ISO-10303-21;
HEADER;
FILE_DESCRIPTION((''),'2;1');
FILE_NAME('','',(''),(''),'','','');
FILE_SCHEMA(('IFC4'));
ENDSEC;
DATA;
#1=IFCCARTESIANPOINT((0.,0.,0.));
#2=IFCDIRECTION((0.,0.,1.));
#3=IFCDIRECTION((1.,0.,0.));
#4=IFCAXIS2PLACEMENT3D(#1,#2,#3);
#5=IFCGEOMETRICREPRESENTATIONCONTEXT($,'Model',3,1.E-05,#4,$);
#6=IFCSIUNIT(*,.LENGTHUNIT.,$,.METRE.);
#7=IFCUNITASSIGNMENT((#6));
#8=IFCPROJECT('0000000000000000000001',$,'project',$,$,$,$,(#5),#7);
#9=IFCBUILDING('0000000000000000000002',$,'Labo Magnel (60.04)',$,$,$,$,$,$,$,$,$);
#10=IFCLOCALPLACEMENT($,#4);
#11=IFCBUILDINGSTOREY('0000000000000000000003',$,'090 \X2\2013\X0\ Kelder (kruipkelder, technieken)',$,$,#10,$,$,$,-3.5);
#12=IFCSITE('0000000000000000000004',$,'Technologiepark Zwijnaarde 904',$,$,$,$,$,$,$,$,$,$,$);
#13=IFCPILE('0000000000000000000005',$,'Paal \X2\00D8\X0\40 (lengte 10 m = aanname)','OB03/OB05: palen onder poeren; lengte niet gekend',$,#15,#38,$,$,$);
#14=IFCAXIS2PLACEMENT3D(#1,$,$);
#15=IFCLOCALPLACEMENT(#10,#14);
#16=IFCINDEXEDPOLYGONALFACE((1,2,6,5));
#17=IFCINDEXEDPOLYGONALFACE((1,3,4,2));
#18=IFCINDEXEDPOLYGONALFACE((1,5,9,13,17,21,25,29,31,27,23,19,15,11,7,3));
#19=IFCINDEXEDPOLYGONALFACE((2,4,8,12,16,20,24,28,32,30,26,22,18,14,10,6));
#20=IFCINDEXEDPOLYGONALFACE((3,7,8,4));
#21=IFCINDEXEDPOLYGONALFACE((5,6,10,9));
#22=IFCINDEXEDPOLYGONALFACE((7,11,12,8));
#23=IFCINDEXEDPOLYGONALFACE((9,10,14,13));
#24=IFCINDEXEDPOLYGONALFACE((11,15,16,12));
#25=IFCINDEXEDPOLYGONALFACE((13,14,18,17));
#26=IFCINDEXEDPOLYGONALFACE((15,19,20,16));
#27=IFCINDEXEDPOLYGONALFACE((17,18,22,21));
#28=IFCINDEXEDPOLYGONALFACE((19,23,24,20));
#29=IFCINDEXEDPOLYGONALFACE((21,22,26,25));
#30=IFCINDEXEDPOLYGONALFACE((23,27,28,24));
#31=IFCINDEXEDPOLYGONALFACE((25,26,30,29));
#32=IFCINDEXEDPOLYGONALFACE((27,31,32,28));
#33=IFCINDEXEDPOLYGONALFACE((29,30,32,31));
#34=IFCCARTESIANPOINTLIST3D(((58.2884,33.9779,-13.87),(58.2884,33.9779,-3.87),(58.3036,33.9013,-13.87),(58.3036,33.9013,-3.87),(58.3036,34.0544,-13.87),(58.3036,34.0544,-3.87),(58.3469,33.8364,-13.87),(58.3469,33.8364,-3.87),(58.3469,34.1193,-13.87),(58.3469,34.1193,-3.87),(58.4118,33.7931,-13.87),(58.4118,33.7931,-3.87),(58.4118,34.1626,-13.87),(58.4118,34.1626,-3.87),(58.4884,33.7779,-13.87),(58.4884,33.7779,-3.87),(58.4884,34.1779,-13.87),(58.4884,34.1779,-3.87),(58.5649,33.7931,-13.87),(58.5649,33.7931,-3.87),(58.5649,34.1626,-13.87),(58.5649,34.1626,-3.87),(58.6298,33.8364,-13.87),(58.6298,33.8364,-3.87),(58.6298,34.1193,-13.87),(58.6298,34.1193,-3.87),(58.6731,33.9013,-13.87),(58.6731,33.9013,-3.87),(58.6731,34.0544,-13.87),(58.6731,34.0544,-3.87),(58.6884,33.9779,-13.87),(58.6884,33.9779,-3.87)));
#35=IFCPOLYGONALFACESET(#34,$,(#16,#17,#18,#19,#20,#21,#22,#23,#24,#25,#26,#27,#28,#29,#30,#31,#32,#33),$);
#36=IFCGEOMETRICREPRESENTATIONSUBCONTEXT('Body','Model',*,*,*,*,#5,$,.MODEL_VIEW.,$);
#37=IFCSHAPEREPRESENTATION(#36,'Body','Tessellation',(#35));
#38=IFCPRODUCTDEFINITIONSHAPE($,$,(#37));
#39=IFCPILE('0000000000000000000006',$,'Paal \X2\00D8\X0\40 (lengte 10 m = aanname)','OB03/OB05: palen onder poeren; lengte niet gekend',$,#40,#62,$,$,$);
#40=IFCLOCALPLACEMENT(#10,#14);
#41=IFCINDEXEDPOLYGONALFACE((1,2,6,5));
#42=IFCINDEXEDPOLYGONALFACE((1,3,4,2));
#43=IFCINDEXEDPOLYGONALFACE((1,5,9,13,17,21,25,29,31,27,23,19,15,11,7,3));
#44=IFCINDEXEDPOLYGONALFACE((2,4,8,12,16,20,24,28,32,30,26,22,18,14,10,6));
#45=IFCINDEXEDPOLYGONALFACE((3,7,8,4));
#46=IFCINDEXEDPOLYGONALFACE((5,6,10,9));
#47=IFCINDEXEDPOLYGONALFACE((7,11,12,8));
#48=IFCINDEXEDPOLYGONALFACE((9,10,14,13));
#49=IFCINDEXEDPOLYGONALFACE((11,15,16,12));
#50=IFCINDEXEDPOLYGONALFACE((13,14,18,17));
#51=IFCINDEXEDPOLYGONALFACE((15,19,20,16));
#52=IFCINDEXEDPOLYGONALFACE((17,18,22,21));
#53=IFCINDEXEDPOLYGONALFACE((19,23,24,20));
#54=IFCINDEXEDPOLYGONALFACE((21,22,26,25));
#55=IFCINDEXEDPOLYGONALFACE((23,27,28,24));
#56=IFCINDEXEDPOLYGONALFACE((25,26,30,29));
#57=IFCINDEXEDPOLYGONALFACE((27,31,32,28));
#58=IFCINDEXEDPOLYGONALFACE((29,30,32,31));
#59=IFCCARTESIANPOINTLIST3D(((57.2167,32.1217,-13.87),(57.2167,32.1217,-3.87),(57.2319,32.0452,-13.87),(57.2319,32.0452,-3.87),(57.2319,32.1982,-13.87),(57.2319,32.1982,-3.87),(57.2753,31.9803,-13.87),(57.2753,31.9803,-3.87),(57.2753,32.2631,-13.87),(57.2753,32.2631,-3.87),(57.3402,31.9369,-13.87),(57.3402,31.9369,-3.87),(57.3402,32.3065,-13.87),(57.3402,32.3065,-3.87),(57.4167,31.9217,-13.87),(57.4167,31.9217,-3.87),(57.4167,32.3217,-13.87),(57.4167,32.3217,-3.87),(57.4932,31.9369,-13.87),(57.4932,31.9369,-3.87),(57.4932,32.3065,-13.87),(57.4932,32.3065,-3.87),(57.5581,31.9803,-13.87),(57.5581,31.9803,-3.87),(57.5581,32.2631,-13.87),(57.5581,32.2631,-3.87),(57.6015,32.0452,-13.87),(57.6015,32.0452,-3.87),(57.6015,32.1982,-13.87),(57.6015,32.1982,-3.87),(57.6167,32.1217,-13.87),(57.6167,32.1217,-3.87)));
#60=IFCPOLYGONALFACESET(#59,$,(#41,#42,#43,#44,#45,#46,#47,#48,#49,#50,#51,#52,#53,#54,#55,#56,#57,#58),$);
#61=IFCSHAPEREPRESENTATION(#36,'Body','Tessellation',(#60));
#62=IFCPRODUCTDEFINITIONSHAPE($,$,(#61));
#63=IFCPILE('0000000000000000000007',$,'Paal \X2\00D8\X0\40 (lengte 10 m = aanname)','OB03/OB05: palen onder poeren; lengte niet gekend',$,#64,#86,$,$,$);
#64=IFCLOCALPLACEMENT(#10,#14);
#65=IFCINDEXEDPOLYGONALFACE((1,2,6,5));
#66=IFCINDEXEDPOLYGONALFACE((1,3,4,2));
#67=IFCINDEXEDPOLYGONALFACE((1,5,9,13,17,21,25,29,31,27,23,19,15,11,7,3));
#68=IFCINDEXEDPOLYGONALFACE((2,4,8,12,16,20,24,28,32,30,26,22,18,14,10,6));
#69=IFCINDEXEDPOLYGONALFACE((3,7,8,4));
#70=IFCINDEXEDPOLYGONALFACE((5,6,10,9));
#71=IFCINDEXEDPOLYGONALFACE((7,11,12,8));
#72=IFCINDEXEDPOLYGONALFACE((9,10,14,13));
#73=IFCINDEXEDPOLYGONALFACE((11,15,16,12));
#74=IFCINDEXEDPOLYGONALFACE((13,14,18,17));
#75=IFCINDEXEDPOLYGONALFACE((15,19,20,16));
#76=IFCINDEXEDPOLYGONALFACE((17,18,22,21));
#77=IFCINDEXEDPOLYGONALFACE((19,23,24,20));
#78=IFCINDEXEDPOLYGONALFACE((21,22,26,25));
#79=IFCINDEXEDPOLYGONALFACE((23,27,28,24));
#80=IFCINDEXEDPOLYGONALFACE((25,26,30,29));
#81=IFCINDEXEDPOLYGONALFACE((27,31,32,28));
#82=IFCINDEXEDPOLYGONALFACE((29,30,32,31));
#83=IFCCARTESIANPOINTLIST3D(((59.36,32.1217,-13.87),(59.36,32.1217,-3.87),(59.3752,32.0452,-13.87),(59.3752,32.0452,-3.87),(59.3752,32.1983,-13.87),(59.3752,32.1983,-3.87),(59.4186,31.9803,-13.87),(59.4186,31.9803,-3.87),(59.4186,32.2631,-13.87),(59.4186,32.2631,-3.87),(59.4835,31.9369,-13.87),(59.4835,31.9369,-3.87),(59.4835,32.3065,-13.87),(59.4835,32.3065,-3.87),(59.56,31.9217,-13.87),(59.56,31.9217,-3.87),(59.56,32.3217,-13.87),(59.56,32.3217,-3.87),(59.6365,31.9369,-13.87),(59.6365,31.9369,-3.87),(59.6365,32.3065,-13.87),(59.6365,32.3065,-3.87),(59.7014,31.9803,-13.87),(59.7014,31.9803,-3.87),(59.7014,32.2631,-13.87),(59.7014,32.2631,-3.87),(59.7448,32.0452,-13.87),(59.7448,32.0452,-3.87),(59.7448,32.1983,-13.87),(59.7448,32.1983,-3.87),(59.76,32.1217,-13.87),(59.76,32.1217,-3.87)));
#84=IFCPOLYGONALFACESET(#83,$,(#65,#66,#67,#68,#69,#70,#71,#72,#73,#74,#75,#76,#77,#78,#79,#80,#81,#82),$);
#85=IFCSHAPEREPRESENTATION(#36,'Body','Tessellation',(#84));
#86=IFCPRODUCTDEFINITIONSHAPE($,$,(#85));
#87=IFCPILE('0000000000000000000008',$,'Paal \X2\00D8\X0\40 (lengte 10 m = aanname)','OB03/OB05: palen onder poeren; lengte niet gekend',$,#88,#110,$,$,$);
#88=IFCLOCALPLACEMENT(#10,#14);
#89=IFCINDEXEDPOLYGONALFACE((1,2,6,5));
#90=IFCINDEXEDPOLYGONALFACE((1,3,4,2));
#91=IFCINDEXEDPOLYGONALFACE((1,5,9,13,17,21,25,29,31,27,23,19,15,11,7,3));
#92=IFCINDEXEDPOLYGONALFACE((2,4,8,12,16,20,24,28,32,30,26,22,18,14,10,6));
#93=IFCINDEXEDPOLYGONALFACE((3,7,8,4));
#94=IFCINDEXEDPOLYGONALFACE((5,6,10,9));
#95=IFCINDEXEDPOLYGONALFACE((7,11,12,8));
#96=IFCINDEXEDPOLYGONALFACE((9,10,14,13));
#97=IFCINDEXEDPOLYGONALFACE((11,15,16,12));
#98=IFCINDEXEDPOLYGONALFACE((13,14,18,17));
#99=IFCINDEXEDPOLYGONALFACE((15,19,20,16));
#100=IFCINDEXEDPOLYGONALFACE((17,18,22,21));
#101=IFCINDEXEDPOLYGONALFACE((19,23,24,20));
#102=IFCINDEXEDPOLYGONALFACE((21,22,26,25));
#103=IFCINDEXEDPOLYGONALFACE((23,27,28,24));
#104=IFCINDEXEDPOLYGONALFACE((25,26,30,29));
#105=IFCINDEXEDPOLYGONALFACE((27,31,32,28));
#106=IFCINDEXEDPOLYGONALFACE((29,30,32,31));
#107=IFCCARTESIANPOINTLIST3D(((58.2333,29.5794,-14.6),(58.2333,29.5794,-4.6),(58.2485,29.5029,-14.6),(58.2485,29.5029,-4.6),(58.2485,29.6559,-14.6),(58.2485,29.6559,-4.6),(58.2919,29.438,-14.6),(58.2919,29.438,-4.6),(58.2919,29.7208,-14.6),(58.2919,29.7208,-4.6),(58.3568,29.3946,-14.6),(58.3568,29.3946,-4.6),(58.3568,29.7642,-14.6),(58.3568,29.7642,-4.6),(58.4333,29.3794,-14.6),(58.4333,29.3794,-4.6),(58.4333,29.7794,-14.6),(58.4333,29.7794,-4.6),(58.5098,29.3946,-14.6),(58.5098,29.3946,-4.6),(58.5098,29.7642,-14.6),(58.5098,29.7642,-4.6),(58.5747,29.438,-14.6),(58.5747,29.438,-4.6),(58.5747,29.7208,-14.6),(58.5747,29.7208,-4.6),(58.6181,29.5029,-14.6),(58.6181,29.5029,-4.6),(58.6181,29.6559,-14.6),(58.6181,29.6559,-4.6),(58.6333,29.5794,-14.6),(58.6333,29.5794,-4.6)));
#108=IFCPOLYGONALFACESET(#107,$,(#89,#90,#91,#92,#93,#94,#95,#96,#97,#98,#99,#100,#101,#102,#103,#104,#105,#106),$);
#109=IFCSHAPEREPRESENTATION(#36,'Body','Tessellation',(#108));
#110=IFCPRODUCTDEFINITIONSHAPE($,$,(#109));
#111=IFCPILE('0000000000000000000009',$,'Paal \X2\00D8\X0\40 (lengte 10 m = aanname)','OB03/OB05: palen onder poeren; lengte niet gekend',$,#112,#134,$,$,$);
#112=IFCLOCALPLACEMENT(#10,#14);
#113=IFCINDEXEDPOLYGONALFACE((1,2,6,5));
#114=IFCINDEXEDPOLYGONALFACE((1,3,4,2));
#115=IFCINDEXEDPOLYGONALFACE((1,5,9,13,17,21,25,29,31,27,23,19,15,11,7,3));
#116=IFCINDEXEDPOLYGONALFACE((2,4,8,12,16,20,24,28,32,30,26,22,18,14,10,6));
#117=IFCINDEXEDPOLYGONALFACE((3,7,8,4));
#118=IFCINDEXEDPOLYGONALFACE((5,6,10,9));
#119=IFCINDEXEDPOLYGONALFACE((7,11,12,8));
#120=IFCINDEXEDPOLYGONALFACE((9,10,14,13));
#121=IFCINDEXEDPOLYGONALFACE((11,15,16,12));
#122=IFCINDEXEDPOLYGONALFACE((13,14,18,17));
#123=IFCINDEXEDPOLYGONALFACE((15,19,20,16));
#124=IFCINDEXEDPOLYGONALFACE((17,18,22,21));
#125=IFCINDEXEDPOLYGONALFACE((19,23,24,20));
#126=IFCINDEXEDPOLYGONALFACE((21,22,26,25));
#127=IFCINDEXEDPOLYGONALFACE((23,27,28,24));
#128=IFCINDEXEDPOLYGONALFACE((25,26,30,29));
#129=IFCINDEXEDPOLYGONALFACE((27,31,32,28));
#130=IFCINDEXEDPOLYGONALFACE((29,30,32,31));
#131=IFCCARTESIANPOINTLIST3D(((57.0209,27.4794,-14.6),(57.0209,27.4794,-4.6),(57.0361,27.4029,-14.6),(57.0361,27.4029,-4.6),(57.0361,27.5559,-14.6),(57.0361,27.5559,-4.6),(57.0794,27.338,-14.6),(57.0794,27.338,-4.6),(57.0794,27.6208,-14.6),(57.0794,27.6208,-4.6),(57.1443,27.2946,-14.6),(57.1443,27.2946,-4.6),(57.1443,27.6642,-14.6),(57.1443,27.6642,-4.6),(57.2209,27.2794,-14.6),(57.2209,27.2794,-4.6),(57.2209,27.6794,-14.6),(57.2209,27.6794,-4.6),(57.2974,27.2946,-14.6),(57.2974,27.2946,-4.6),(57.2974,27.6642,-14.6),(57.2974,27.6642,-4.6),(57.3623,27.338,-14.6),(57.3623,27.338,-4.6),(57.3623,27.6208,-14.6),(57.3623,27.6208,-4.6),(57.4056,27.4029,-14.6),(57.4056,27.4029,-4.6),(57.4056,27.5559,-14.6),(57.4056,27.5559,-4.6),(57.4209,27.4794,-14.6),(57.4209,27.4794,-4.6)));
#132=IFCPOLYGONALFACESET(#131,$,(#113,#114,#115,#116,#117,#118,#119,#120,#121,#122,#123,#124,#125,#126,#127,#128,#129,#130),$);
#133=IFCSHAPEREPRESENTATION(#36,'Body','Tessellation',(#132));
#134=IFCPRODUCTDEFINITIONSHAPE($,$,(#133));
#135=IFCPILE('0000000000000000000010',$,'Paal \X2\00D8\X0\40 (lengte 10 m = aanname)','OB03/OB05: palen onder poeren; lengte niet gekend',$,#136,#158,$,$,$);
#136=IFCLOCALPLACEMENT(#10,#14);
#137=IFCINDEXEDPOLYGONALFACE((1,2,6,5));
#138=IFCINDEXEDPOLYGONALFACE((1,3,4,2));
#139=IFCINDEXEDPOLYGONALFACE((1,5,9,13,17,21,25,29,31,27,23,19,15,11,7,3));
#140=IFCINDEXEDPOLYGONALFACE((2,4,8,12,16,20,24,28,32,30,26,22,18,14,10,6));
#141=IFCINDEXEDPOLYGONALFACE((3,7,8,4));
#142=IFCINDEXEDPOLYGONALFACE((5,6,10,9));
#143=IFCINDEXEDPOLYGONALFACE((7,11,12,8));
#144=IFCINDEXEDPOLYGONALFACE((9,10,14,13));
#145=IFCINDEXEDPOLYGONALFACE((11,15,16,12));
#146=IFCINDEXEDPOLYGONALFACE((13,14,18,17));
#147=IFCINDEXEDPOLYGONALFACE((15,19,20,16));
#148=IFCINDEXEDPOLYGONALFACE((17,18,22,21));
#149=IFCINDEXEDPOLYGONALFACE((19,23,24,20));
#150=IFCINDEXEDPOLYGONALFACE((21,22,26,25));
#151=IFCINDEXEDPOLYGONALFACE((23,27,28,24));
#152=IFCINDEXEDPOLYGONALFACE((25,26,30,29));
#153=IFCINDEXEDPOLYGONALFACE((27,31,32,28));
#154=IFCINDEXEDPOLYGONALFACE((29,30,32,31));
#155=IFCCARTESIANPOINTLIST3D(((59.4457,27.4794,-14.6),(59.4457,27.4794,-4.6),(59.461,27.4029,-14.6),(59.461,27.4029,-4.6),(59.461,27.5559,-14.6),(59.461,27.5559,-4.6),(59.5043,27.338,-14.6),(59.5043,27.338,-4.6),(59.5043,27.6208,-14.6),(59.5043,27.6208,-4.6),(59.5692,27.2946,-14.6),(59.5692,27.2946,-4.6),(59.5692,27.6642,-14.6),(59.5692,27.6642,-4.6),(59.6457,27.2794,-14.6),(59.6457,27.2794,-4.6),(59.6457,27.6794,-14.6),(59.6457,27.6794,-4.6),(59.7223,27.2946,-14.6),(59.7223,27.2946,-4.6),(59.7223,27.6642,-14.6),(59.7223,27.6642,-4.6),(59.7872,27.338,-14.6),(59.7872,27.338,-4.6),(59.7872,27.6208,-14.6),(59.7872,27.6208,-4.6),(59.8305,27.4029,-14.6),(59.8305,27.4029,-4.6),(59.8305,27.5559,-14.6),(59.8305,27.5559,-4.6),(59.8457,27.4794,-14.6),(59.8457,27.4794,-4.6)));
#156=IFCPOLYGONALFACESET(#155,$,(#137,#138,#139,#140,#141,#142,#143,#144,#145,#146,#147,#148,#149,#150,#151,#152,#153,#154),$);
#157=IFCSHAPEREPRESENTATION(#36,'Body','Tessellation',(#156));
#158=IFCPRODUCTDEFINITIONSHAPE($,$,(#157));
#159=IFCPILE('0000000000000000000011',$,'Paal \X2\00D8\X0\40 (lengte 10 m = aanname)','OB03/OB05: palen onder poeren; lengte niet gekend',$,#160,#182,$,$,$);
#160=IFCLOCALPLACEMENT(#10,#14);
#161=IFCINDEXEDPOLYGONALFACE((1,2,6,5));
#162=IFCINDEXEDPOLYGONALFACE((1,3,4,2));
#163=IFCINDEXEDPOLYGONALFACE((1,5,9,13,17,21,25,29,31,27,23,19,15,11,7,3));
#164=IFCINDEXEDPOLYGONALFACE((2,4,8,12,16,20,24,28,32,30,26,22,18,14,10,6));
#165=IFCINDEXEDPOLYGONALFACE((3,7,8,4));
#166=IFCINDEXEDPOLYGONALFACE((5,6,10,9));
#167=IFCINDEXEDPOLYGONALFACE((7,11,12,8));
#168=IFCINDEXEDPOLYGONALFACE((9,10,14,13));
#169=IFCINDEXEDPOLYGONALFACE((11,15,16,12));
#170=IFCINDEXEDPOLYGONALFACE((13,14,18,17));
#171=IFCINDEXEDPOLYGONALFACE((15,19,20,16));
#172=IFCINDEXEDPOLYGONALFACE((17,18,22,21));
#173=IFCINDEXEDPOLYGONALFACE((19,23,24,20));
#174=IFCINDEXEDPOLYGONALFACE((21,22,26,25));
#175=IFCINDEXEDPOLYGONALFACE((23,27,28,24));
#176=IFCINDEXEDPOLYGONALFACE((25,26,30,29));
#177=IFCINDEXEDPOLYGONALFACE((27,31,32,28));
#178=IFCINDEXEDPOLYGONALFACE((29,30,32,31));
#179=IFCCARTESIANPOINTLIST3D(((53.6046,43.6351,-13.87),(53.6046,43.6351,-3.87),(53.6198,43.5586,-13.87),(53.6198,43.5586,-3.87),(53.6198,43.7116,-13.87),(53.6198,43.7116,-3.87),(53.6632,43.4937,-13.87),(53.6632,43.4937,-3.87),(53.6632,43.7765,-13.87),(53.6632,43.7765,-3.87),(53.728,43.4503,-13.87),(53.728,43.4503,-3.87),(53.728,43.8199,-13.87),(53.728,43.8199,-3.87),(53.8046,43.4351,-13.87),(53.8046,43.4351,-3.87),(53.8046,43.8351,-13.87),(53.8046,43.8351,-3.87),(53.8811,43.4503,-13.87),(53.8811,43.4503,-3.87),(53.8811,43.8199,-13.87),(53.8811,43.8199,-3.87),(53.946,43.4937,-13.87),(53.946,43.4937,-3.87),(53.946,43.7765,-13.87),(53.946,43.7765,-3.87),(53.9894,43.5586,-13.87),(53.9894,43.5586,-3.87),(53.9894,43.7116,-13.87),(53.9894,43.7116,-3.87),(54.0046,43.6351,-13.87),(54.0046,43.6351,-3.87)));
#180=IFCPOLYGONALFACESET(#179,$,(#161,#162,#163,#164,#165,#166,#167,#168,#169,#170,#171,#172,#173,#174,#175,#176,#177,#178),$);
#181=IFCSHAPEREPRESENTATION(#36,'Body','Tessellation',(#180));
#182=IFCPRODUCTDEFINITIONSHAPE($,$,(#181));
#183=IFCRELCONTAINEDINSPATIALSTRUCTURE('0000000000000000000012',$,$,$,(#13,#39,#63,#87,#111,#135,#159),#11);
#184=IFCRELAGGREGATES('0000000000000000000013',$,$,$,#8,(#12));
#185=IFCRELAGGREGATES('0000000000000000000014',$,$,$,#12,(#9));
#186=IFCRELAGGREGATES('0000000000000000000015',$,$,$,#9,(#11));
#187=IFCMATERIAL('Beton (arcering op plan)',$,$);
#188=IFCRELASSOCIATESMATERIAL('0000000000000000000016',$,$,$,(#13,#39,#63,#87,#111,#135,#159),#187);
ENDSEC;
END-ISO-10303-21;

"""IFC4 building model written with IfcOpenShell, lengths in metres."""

from ifc_helpers import new_model, si_unit, frame, origin, origin_with_axes, place, context, subcontext, project, spatial, polyline, outline, extrude, material, element, save


model = new_model("IFC4")

# Units and contexts
model_context = context("Model", 3, precision=1e-05, world=origin_with_axes())
body_context = subcontext(model_context, "Body", "Model", "MODEL_VIEW")
ifc_project = project(units=[si_unit("LENGTHUNIT", "METRE")], contexts=[model_context])

# Site, building, storey
site = spatial("IfcSite", under=ifc_project, Name="Technologiepark Zwijnaarde 904")
building = spatial("IfcBuilding", under=site, Name="Labo Magnel (60.04)")
storey_placement = place(None, origin_with_axes())
storey = spatial("IfcBuildingStorey", under=building, at=storey_placement, Name="090 – Kelder (kruipkelder, technieken)", Elevation=-3.5)

# Piles
ifc_material = material(Name="Beton (arcering op plan)")
pile_1_placement = place(storey_placement, frame((0.0, 0.0, -13.87), z_axis=(0.0, 0.0, 1.0), x_axis=(1.0, 0.0, 0.0)))
element("IfcPile", 1, at=pile_1_placement, inside=storey, material=ifc_material, Name="Paal Ø40 (lengte 10 m = aanname)", Description="OB03/OB05: palen onder poeren; lengte niet gekend", context=body_context, shape_type="SweptSolid", body=[
    extrude(outline(polyline([(58.6884, 33.9779), (58.6731, 33.9013), (58.6298, 33.8364), (58.5649, 33.7931), (58.4884, 33.7779), (58.4118, 33.7931), (58.3469, 33.8364), (58.3036, 33.9013), (58.2884, 33.9779), (58.3036, 34.0544), (58.3469, 34.1193), (58.4118, 34.1626), (58.4884, 34.1779), (58.5649, 34.1626), (58.6298, 34.1193), (58.6731, 34.0544), (58.6884, 33.9779)])), origin(), (0.0, 0.0, 1.0), 10.0),
])
pile_2_placement = place(storey_placement, frame((0.0, 0.0, -13.87), z_axis=(0.0, 0.0, 1.0), x_axis=(1.0, 0.0, 0.0)))
element("IfcPile", 2, at=pile_2_placement, inside=storey, material=ifc_material, Name="Paal Ø40 (lengte 10 m = aanname)", Description="OB03/OB05: palen onder poeren; lengte niet gekend", context=body_context, shape_type="SweptSolid", body=[
    extrude(outline(polyline([(57.6167, 32.1217), (57.6015, 32.0452), (57.5581, 31.9803), (57.4932, 31.9369), (57.4167, 31.9217), (57.3402, 31.9369), (57.2753, 31.9803), (57.2319, 32.0452), (57.2167, 32.1217), (57.2319, 32.1982), (57.2753, 32.2631), (57.3402, 32.3065), (57.4167, 32.3217), (57.4932, 32.3065), (57.5581, 32.2631), (57.6015, 32.1982), (57.6167, 32.1217)])), origin(), (0.0, 0.0, 1.0), 10.0),
])
pile_3_placement = place(storey_placement, frame((0.0, 0.0, -13.87), z_axis=(0.0, 0.0, 1.0), x_axis=(1.0, 0.0, 0.0)))
element("IfcPile", 3, at=pile_3_placement, inside=storey, material=ifc_material, Name="Paal Ø40 (lengte 10 m = aanname)", Description="OB03/OB05: palen onder poeren; lengte niet gekend", context=body_context, shape_type="SweptSolid", body=[
    extrude(outline(polyline([(59.76, 32.1217), (59.7448, 32.0452), (59.7014, 31.9803), (59.6365, 31.9369), (59.56, 31.9217), (59.4835, 31.9369), (59.4186, 31.9803), (59.3752, 32.0452), (59.36, 32.1217), (59.3752, 32.1983), (59.4186, 32.2631), (59.4835, 32.3065), (59.56, 32.3217), (59.6365, 32.3065), (59.7014, 32.2631), (59.7448, 32.1983), (59.76, 32.1217)])), origin(), (0.0, 0.0, 1.0), 10.0),
])
pile_4_placement = place(storey_placement, frame((0.0, 0.0, -14.6), z_axis=(0.0, 0.0, 1.0), x_axis=(1.0, 0.0, 0.0)))
element("IfcPile", 4, at=pile_4_placement, inside=storey, material=ifc_material, Name="Paal Ø40 (lengte 10 m = aanname)", Description="OB03/OB05: palen onder poeren; lengte niet gekend", context=body_context, shape_type="SweptSolid", body=[
    extrude(outline(polyline([(58.6333, 29.5794), (58.6181, 29.5029), (58.5747, 29.438), (58.5098, 29.3946), (58.4333, 29.3794), (58.3568, 29.3946), (58.2919, 29.438), (58.2485, 29.5029), (58.2333, 29.5794), (58.2485, 29.6559), (58.2919, 29.7208), (58.3568, 29.7642), (58.4333, 29.7794), (58.5098, 29.7642), (58.5747, 29.7208), (58.6181, 29.6559), (58.6333, 29.5794)])), origin(), (0.0, 0.0, 1.0), 10.0),
])
pile_5_placement = place(storey_placement, frame((0.0, 0.0, -14.6), z_axis=(0.0, 0.0, 1.0), x_axis=(1.0, 0.0, 0.0)))
element("IfcPile", 5, at=pile_5_placement, inside=storey, material=ifc_material, Name="Paal Ø40 (lengte 10 m = aanname)", Description="OB03/OB05: palen onder poeren; lengte niet gekend", context=body_context, shape_type="SweptSolid", body=[
    extrude(outline(polyline([(57.4209, 27.4794), (57.4056, 27.4029), (57.3623, 27.338), (57.2974, 27.2946), (57.2209, 27.2794), (57.1443, 27.2946), (57.0794, 27.338), (57.0361, 27.4029), (57.0209, 27.4794), (57.0361, 27.5559), (57.0794, 27.6208), (57.1443, 27.6642), (57.2209, 27.6794), (57.2974, 27.6642), (57.3623, 27.6208), (57.4056, 27.5559), (57.4209, 27.4794)])), origin(), (0.0, 0.0, 1.0), 10.0),
])
pile_6_placement = place(storey_placement, frame((0.0, 0.0, -14.6), z_axis=(0.0, 0.0, 1.0), x_axis=(1.0, 0.0, 0.0)))
element("IfcPile", 6, at=pile_6_placement, inside=storey, material=ifc_material, Name="Paal Ø40 (lengte 10 m = aanname)", Description="OB03/OB05: palen onder poeren; lengte niet gekend", context=body_context, shape_type="SweptSolid", body=[
    extrude(outline(polyline([(59.8457, 27.4794), (59.8305, 27.4029), (59.7872, 27.338), (59.7223, 27.2946), (59.6457, 27.2794), (59.5692, 27.2946), (59.5043, 27.338), (59.461, 27.4029), (59.4457, 27.4794), (59.461, 27.5559), (59.5043, 27.6208), (59.5692, 27.6642), (59.6457, 27.6794), (59.7223, 27.6642), (59.7872, 27.6208), (59.8305, 27.5559), (59.8457, 27.4794)])), origin(), (0.0, 0.0, 1.0), 10.0),
])
pile_7_placement = place(storey_placement, frame((0.0, 0.0, -13.87), z_axis=(0.0, 0.0, 1.0), x_axis=(1.0, 0.0, 0.0)))
element("IfcPile", 7, at=pile_7_placement, inside=storey, material=ifc_material, Name="Paal Ø40 (lengte 10 m = aanname)", Description="OB03/OB05: palen onder poeren; lengte niet gekend", context=body_context, shape_type="SweptSolid", body=[
    extrude(outline(polyline([(54.0046, 43.6351), (53.9894, 43.5586), (53.946, 43.4937), (53.8811, 43.4503), (53.8046, 43.4351), (53.728, 43.4503), (53.6632, 43.4937), (53.6198, 43.5586), (53.6046, 43.6351), (53.6198, 43.7116), (53.6632, 43.7765), (53.728, 43.8199), (53.8046, 43.8351), (53.8811, 43.8199), (53.946, 43.7765), (53.9894, 43.7116), (54.0046, 43.6351)])), origin(), (0.0, 0.0, 1.0), 10.0),
])

save(model, "model.ifc")
